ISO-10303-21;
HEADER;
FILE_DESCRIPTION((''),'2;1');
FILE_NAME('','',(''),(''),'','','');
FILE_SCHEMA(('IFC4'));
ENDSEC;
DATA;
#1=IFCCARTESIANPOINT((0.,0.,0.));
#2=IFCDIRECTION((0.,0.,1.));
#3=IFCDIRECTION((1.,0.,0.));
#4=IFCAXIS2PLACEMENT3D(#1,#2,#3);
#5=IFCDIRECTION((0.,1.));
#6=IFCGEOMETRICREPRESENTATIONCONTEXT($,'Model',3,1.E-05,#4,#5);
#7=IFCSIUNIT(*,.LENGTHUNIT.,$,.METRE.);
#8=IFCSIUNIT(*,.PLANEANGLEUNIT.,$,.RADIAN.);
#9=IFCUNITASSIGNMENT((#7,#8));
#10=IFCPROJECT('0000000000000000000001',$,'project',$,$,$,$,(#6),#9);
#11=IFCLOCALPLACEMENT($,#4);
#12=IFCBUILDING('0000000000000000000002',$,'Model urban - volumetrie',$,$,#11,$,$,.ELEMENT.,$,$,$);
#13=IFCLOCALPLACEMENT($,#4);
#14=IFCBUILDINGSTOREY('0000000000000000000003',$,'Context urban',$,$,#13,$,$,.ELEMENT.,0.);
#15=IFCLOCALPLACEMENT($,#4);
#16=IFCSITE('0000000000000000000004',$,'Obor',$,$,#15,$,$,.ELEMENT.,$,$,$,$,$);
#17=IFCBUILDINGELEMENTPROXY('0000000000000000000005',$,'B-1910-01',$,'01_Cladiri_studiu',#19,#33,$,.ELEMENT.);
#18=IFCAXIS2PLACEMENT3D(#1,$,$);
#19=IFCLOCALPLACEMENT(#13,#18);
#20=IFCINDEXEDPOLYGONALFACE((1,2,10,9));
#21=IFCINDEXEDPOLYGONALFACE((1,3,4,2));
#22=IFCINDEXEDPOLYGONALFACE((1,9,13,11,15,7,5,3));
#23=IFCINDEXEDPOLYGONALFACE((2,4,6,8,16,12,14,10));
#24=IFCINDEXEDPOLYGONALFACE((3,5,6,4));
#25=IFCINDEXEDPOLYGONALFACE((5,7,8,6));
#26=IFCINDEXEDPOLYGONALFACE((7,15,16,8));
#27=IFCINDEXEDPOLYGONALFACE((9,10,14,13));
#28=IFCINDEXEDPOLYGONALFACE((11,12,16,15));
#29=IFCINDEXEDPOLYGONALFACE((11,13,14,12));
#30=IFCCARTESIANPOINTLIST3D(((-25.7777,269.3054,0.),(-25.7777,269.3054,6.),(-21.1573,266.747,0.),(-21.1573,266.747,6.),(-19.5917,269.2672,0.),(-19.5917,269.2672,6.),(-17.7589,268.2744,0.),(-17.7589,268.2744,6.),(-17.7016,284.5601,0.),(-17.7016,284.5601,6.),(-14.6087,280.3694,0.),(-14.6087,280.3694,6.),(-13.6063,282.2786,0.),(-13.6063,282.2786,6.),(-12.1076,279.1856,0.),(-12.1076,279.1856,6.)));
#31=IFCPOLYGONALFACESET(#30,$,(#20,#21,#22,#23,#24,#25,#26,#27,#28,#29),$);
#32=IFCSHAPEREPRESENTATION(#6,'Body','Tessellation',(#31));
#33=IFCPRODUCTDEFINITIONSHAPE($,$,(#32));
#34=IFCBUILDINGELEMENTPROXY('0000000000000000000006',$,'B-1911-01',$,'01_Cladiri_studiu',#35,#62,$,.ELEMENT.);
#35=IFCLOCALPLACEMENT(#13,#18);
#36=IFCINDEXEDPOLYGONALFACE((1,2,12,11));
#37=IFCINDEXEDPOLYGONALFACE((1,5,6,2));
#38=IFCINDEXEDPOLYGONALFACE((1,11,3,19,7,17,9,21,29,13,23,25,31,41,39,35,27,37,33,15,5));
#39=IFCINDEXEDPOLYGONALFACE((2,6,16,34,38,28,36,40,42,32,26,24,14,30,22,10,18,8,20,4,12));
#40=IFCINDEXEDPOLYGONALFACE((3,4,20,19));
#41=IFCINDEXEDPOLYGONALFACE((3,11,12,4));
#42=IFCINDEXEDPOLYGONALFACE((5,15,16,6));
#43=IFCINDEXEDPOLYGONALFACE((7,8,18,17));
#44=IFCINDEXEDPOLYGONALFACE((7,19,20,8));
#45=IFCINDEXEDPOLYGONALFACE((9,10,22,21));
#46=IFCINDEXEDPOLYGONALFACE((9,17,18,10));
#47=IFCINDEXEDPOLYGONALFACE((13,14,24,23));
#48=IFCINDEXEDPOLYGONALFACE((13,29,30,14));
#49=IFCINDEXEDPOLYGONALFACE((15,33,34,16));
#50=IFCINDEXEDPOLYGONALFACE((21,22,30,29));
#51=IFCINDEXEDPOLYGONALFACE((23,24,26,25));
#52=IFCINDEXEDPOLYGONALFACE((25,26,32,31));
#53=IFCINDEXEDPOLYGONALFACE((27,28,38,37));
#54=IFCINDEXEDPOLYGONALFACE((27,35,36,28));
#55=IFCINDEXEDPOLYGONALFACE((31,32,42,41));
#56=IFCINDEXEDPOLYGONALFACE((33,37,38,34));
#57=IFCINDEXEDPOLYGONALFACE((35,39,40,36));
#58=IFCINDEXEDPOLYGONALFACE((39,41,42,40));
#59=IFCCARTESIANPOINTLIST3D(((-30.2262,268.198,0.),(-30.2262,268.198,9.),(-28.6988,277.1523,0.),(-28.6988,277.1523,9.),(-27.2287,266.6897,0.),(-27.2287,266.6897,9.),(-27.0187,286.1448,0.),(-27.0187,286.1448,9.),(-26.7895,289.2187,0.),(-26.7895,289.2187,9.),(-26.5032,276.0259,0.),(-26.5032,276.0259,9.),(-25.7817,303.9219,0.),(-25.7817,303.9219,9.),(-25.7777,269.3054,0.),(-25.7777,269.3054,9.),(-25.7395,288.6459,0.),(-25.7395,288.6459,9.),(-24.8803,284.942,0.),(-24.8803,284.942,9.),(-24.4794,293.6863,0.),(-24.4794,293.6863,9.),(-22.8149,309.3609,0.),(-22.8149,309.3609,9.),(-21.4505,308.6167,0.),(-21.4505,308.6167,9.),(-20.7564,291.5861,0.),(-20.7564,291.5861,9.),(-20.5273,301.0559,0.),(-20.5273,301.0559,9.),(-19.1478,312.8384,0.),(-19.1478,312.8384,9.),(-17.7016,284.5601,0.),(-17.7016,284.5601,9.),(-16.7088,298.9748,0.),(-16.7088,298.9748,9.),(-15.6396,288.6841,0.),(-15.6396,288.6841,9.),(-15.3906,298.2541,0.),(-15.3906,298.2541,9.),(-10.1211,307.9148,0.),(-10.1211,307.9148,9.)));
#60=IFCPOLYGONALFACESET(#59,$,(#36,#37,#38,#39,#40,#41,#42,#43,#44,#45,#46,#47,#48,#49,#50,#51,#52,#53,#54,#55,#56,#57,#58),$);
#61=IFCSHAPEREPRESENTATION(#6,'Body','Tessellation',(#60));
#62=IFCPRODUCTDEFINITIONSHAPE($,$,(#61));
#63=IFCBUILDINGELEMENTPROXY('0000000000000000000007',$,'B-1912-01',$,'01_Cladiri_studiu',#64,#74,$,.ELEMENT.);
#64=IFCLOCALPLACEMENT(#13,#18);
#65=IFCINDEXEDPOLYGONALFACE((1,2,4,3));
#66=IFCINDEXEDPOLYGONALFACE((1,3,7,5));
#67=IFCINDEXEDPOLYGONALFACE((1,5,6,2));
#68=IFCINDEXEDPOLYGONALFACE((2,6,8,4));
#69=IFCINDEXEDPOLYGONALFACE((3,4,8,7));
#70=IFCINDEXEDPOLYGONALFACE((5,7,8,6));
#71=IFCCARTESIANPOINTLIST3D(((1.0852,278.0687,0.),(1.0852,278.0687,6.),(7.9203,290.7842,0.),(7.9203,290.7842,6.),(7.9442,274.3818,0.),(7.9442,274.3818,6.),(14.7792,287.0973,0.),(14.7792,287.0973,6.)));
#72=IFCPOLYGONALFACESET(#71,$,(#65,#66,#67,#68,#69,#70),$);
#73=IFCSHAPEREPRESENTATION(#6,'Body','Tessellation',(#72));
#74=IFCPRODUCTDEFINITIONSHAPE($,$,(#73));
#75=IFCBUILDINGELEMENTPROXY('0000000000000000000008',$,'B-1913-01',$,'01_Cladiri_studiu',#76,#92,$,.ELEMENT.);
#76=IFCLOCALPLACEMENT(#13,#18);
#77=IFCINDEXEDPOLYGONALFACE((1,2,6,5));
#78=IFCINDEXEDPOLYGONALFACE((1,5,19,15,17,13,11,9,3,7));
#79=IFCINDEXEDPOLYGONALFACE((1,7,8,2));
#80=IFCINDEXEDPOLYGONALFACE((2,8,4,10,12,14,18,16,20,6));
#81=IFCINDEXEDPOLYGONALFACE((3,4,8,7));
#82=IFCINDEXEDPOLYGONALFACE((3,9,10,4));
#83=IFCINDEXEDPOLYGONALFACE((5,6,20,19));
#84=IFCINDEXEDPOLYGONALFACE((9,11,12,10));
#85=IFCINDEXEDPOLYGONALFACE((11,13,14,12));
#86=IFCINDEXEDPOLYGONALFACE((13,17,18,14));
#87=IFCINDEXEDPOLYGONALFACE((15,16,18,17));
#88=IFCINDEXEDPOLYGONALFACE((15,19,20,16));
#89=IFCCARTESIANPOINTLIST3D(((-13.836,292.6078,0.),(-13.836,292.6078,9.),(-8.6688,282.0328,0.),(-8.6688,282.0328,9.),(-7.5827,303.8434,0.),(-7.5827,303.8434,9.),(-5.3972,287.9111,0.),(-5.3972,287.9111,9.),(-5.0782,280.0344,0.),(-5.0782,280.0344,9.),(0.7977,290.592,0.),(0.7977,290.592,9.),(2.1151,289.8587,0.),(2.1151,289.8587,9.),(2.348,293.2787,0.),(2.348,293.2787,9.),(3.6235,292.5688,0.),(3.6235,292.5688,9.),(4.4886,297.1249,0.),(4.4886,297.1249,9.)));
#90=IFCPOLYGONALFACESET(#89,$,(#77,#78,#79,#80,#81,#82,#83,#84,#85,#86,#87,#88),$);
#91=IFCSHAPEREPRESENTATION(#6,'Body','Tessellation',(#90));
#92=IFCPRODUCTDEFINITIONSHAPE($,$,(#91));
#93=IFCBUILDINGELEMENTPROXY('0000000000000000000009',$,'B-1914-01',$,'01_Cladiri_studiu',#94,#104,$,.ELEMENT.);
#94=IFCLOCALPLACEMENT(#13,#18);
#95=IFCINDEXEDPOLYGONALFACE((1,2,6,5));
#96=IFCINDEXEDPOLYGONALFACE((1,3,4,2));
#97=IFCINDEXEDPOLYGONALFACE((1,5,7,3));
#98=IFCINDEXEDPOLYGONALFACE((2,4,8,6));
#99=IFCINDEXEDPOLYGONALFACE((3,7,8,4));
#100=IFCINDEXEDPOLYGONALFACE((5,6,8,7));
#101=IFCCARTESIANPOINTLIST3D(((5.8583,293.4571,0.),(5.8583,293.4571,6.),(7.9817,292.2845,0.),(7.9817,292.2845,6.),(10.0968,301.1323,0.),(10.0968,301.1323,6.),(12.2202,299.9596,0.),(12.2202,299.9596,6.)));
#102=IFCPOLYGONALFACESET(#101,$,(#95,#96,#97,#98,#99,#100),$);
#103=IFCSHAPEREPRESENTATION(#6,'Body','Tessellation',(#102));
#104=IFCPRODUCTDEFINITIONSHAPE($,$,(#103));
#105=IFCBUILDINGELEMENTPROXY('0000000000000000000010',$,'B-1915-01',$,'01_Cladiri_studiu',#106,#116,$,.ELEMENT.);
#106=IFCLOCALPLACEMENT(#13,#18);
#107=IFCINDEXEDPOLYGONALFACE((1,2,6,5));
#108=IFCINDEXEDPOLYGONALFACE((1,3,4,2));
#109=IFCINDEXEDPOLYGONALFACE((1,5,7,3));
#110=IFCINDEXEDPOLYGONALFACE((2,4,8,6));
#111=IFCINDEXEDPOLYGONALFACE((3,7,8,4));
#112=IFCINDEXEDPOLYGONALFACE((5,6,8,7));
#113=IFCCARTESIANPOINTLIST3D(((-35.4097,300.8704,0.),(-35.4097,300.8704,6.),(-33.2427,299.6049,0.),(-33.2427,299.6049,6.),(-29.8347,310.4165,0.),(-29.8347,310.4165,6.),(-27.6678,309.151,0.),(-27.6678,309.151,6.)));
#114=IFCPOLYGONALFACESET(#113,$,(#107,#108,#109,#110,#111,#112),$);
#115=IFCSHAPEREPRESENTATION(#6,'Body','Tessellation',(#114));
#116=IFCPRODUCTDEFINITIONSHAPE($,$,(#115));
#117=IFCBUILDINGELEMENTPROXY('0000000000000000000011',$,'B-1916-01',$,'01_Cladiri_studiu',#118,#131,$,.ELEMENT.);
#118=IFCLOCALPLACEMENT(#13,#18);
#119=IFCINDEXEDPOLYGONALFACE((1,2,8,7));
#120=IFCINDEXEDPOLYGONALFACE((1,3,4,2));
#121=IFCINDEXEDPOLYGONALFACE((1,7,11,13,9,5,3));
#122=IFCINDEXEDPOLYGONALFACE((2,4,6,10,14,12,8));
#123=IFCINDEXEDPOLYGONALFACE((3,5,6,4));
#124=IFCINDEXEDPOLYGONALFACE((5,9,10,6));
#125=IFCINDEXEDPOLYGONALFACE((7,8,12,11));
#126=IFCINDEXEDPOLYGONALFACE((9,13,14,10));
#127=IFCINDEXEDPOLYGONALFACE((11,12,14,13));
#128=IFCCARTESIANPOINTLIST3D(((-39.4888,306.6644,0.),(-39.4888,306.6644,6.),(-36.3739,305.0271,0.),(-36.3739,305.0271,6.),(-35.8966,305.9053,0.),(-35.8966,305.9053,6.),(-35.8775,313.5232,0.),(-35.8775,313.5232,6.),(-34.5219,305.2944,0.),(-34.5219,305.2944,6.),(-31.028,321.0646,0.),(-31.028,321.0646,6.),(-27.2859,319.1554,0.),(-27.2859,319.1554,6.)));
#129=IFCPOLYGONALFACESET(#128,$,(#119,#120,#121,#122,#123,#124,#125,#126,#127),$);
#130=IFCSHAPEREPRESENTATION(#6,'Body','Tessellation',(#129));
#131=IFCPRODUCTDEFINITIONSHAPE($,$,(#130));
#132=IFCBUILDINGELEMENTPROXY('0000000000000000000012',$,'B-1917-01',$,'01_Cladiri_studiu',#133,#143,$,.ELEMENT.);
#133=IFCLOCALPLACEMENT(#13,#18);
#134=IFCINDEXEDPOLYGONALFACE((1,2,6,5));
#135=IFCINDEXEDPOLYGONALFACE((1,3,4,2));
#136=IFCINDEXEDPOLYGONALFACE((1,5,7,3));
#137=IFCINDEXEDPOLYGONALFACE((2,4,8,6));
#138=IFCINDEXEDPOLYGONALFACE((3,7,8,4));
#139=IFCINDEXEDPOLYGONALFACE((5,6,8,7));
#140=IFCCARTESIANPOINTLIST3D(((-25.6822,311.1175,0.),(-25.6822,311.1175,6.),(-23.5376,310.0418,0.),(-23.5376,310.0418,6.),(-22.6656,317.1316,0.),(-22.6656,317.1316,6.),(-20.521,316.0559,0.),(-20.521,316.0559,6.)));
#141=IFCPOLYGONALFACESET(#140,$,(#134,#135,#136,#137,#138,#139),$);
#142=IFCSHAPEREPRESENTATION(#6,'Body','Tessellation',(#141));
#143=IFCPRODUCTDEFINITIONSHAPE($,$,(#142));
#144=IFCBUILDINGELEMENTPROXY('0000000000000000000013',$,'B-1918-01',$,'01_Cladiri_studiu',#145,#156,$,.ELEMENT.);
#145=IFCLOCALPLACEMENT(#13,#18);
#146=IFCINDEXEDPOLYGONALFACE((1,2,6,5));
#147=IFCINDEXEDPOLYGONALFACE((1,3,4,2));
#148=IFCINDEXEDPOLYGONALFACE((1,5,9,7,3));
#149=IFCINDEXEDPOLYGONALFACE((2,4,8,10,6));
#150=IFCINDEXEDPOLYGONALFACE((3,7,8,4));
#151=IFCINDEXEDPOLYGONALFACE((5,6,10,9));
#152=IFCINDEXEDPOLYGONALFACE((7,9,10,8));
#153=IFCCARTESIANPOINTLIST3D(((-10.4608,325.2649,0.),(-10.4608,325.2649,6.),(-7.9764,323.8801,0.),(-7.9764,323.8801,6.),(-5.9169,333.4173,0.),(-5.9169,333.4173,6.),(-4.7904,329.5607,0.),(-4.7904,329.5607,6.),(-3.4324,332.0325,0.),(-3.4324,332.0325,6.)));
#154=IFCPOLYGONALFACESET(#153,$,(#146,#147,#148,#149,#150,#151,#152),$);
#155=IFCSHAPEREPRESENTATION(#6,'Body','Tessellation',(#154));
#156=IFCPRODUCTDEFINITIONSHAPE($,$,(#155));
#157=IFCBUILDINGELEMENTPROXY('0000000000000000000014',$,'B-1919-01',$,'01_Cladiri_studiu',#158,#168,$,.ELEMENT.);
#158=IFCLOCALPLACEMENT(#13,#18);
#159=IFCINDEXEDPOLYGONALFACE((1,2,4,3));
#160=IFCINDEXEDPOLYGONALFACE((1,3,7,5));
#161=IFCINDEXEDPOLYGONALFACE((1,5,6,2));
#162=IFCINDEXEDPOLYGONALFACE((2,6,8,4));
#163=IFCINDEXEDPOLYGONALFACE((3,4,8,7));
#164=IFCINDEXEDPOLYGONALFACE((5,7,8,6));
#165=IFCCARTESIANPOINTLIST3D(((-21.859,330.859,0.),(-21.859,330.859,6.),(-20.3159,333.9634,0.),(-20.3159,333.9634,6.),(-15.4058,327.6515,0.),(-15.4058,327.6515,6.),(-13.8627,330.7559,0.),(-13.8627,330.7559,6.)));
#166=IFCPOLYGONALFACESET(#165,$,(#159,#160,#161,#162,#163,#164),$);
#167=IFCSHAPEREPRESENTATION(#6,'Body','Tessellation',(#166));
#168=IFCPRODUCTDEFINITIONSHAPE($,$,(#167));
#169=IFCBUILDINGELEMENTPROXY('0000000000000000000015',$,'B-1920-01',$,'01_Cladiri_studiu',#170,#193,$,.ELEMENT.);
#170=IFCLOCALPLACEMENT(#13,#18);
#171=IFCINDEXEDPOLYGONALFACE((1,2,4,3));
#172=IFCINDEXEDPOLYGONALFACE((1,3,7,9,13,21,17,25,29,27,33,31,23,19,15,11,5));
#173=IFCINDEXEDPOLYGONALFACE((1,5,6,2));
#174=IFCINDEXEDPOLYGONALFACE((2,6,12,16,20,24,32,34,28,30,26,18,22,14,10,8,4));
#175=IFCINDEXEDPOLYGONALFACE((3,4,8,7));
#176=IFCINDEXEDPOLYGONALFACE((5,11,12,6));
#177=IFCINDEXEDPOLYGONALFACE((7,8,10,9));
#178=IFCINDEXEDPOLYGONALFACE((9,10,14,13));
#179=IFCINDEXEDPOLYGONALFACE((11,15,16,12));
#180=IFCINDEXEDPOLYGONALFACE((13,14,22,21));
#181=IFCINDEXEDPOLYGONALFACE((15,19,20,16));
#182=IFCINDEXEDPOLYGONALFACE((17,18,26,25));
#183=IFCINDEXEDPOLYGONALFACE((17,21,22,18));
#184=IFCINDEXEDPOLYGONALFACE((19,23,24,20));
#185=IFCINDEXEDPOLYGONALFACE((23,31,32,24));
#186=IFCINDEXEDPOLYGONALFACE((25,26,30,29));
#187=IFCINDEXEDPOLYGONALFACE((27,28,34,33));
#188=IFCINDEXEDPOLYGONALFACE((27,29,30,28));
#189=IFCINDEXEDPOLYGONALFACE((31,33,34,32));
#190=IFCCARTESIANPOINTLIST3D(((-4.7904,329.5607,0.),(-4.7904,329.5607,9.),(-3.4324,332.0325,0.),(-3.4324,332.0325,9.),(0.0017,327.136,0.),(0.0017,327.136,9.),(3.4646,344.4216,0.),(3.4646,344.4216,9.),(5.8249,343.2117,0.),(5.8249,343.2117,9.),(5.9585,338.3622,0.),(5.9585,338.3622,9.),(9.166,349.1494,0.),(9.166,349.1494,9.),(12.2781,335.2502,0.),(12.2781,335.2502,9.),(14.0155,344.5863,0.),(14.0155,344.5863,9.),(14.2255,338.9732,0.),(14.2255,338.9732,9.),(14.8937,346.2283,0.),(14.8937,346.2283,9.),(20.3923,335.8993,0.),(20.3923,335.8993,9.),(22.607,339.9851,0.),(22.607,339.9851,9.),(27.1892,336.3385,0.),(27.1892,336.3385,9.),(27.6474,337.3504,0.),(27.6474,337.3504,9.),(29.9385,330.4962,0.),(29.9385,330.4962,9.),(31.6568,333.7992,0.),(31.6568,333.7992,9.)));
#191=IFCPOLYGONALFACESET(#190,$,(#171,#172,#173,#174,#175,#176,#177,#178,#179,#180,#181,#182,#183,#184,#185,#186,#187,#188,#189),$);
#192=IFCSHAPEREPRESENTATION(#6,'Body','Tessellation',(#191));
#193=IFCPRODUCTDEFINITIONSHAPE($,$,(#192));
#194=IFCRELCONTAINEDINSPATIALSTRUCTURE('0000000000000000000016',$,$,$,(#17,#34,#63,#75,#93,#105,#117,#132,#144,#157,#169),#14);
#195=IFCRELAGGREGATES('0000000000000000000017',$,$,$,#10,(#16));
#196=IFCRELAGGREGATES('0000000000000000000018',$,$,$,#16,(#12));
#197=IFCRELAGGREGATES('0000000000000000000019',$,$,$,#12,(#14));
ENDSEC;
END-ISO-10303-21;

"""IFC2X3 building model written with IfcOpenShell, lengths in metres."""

from ifc_helpers import new_model, si_unit, direction, origin_with_axes, place, context, project, spatial, polyline, outline, extrude, element, save


model = new_model("IFC2X3")

# Units and contexts
model_context = context("Model", 3, precision=1e-05, world=origin_with_axes(), true_north=direction((0.0, 1.0)))
ifc_project = project(units=[si_unit("LENGTHUNIT", "METRE"), si_unit("PLANEANGLEUNIT", "RADIAN")], contexts=[model_context])

# Site, building, storey
site_placement = place(None, origin_with_axes())
site = spatial("IfcSite", under=ifc_project, at=site_placement, Name="Obor", CompositionType="ELEMENT")
building_placement = place(None, origin_with_axes())
building = spatial("IfcBuilding", under=site, at=building_placement, Name="Model urban - volumetrie", CompositionType="ELEMENT")
storey_placement = place(None, origin_with_axes())
storey = spatial("IfcBuildingStorey", under=building, at=storey_placement, Name="Context urban", CompositionType="ELEMENT", Elevation=0.0)

# Building element proxies
proxy_1_placement = place(None, origin_with_axes())
element("IfcBuildingElementProxy", 1, at=proxy_1_placement, inside=storey, Name="B-1910-01", ObjectType="01_Cladiri_studiu", CompositionType="ELEMENT", context=model_context, shape_type="SweptSolid", body=[
    extrude(outline(polyline([(-25.7777, 269.3054), (-21.1573, 266.747), (-19.5917, 269.2672), (-17.7589, 268.2744), (-12.1076, 279.1856), (-14.6087, 280.3694), (-13.6063, 282.2786), (-17.7016, 284.5601), (-25.7777, 269.3054)])), origin_with_axes(), (0.0, 0.0, 1.0), 6.0),
])
proxy_2_placement = place(None, origin_with_axes())
element("IfcBuildingElementProxy", 2, at=proxy_2_placement, inside=storey, Name="B-1911-01", ObjectType="01_Cladiri_studiu", CompositionType="ELEMENT", context=model_context, shape_type="SweptSolid", body=[
    extrude(outline(polyline([(-19.1478, 312.8384), (-21.4505, 308.6167), (-22.8149, 309.3609), (-25.7817, 303.9219), (-20.5273, 301.0559), (-24.4794, 293.6863), (-26.7895, 289.2187), (-25.7395, 288.6459), (-27.0187, 286.1448), (-24.8803, 284.942), (-28.6988, 277.1523), (-26.5032, 276.0259), (-30.2262, 268.198), (-27.2287, 266.6897), (-25.7777, 269.3054), (-17.7016, 284.5601), (-15.6396, 288.6841), (-20.7564, 291.5861), (-16.7088, 298.9748), (-15.3906, 298.2541), (-10.1211, 307.9148), (-19.1478, 312.8384)])), origin_with_axes(), (0.0, 0.0, 1.0), 9.0),
])
proxy_3_placement = place(None, origin_with_axes())
element("IfcBuildingElementProxy", 3, at=proxy_3_placement, inside=storey, Name="B-1912-01", ObjectType="01_Cladiri_studiu", CompositionType="ELEMENT", context=model_context, shape_type="SweptSolid", body=[
    extrude(outline(polyline([(14.7792, 287.0973), (7.9203, 290.7842), (1.0852, 278.0687), (7.9442, 274.3818), (14.7792, 287.0973)])), origin_with_axes(), (0.0, 0.0, 1.0), 6.0),
])
proxy_4_placement = place(None, origin_with_axes())
element("IfcBuildingElementProxy", 4, at=proxy_4_placement, inside=storey, Name="B-1913-01", ObjectType="01_Cladiri_studiu", CompositionType="ELEMENT", context=model_context, shape_type="SweptSolid", body=[
    extrude(outline(polyline([(2.1151, 289.8587), (3.6235, 292.5688), (2.348, 293.2787), (4.4886, 297.1249), (-7.5827, 303.8434), (-13.836, 292.6078), (-5.3972, 287.9111), (-8.6688, 282.0328), (-5.0782, 280.0344), (0.7977, 290.592), (2.1151, 289.8587)])), origin_with_axes(), (0.0, 0.0, 1.0), 9.0),
])
proxy_5_placement = place(None, origin_with_axes())
element("IfcBuildingElementProxy", 5, at=proxy_5_placement, inside=storey, Name="B-1914-01", ObjectType="01_Cladiri_studiu", CompositionType="ELEMENT", context=model_context, shape_type="SweptSolid", body=[
    extrude(outline(polyline([(7.9817, 292.2845), (12.2202, 299.9596), (10.0968, 301.1323), (5.8583, 293.4571), (7.9817, 292.2845)])), origin_with_axes(), (0.0, 0.0, 1.0), 6.0),
])
proxy_6_placement = place(None, origin_with_axes())
element("IfcBuildingElementProxy", 6, at=proxy_6_placement, inside=storey, Name="B-1915-01", ObjectType="01_Cladiri_studiu", CompositionType="ELEMENT", context=model_context, shape_type="SweptSolid", body=[
    extrude(outline(polyline([(-29.8347, 310.4165), (-35.4097, 300.8704), (-33.2427, 299.6049), (-27.6678, 309.151), (-29.8347, 310.4165)])), origin_with_axes(), (0.0, 0.0, 1.0), 6.0),
])
proxy_7_placement = place(None, origin_with_axes())
element("IfcBuildingElementProxy", 7, at=proxy_7_placement, inside=storey, Name="B-1916-01", ObjectType="01_Cladiri_studiu", CompositionType="ELEMENT", context=model_context, shape_type="SweptSolid", body=[
    extrude(outline(polyline([(-31.028, 321.0646), (-35.8775, 313.5232), (-39.4888, 306.6644), (-36.3739, 305.0271), (-35.8966, 305.9053), (-34.5219, 305.2944), (-27.2859, 319.1554), (-31.028, 321.0646)])), origin_with_axes(), (0.0, 0.0, 1.0), 6.0),
])
proxy_8_placement = place(None, origin_with_axes())
element("IfcBuildingElementProxy", 8, at=proxy_8_placement, inside=storey, Name="B-1917-01", ObjectType="01_Cladiri_studiu", CompositionType="ELEMENT", context=model_context, shape_type="SweptSolid", body=[
    extrude(outline(polyline([(-25.6822, 311.1175), (-23.5376, 310.0418), (-20.521, 316.0559), (-22.6656, 317.1316), (-25.6822, 311.1175)])), origin_with_axes(), (0.0, 0.0, 1.0), 6.0),
])
proxy_9_placement = place(None, origin_with_axes())
element("IfcBuildingElementProxy", 9, at=proxy_9_placement, inside=storey, Name="B-1918-01", ObjectType="01_Cladiri_studiu", CompositionType="ELEMENT", context=model_context, shape_type="SweptSolid", body=[
    extrude(outline(polyline([(-7.9764, 323.8801), (-4.7904, 329.5607), (-3.4324, 332.0325), (-5.9169, 333.4173), (-10.4608, 325.2649), (-7.9764, 323.8801)])), origin_with_axes(), (0.0, 0.0, 1.0), 6.0),
])
proxy_10_placement = place(None, origin_with_axes())
element("IfcBuildingElementProxy", 10, at=proxy_10_placement, inside=storey, Name="B-1919-01", ObjectType="01_Cladiri_studiu", CompositionType="ELEMENT", context=model_context, shape_type="SweptSolid", body=[
    extrude(outline(polyline([(-13.8627, 330.7559), (-20.3159, 333.9634), (-21.859, 330.859), (-15.4058, 327.6515), (-13.8627, 330.7559)])), origin_with_axes(), (0.0, 0.0, 1.0), 6.0),
])
proxy_11_placement = place(None, origin_with_axes())
element("IfcBuildingElementProxy", 11, at=proxy_11_placement, inside=storey, Name="B-1920-01", ObjectType="01_Cladiri_studiu", CompositionType="ELEMENT", context=model_context, shape_type="SweptSolid", body=[
    extrude(outline(polyline([(27.1892, 336.3385), (27.6474, 337.3504), (22.607, 339.9851), (14.0155, 344.5863), (14.8937, 346.2283), (9.166, 349.1494), (5.8249, 343.2117), (3.4646, 344.4216), (-3.4324, 332.0325), (-4.7904, 329.5607), (0.0017, 327.136), (5.9585, 338.3622), (12.2781, 335.2502), (14.2255, 338.9732), (20.3923, 335.8993), (29.9385, 330.4962), (31.6568, 333.7992), (27.1892, 336.3385)])), origin_with_axes(), (0.0, 0.0, 1.0), 9.0),
])

save(model, "model.ifc")
